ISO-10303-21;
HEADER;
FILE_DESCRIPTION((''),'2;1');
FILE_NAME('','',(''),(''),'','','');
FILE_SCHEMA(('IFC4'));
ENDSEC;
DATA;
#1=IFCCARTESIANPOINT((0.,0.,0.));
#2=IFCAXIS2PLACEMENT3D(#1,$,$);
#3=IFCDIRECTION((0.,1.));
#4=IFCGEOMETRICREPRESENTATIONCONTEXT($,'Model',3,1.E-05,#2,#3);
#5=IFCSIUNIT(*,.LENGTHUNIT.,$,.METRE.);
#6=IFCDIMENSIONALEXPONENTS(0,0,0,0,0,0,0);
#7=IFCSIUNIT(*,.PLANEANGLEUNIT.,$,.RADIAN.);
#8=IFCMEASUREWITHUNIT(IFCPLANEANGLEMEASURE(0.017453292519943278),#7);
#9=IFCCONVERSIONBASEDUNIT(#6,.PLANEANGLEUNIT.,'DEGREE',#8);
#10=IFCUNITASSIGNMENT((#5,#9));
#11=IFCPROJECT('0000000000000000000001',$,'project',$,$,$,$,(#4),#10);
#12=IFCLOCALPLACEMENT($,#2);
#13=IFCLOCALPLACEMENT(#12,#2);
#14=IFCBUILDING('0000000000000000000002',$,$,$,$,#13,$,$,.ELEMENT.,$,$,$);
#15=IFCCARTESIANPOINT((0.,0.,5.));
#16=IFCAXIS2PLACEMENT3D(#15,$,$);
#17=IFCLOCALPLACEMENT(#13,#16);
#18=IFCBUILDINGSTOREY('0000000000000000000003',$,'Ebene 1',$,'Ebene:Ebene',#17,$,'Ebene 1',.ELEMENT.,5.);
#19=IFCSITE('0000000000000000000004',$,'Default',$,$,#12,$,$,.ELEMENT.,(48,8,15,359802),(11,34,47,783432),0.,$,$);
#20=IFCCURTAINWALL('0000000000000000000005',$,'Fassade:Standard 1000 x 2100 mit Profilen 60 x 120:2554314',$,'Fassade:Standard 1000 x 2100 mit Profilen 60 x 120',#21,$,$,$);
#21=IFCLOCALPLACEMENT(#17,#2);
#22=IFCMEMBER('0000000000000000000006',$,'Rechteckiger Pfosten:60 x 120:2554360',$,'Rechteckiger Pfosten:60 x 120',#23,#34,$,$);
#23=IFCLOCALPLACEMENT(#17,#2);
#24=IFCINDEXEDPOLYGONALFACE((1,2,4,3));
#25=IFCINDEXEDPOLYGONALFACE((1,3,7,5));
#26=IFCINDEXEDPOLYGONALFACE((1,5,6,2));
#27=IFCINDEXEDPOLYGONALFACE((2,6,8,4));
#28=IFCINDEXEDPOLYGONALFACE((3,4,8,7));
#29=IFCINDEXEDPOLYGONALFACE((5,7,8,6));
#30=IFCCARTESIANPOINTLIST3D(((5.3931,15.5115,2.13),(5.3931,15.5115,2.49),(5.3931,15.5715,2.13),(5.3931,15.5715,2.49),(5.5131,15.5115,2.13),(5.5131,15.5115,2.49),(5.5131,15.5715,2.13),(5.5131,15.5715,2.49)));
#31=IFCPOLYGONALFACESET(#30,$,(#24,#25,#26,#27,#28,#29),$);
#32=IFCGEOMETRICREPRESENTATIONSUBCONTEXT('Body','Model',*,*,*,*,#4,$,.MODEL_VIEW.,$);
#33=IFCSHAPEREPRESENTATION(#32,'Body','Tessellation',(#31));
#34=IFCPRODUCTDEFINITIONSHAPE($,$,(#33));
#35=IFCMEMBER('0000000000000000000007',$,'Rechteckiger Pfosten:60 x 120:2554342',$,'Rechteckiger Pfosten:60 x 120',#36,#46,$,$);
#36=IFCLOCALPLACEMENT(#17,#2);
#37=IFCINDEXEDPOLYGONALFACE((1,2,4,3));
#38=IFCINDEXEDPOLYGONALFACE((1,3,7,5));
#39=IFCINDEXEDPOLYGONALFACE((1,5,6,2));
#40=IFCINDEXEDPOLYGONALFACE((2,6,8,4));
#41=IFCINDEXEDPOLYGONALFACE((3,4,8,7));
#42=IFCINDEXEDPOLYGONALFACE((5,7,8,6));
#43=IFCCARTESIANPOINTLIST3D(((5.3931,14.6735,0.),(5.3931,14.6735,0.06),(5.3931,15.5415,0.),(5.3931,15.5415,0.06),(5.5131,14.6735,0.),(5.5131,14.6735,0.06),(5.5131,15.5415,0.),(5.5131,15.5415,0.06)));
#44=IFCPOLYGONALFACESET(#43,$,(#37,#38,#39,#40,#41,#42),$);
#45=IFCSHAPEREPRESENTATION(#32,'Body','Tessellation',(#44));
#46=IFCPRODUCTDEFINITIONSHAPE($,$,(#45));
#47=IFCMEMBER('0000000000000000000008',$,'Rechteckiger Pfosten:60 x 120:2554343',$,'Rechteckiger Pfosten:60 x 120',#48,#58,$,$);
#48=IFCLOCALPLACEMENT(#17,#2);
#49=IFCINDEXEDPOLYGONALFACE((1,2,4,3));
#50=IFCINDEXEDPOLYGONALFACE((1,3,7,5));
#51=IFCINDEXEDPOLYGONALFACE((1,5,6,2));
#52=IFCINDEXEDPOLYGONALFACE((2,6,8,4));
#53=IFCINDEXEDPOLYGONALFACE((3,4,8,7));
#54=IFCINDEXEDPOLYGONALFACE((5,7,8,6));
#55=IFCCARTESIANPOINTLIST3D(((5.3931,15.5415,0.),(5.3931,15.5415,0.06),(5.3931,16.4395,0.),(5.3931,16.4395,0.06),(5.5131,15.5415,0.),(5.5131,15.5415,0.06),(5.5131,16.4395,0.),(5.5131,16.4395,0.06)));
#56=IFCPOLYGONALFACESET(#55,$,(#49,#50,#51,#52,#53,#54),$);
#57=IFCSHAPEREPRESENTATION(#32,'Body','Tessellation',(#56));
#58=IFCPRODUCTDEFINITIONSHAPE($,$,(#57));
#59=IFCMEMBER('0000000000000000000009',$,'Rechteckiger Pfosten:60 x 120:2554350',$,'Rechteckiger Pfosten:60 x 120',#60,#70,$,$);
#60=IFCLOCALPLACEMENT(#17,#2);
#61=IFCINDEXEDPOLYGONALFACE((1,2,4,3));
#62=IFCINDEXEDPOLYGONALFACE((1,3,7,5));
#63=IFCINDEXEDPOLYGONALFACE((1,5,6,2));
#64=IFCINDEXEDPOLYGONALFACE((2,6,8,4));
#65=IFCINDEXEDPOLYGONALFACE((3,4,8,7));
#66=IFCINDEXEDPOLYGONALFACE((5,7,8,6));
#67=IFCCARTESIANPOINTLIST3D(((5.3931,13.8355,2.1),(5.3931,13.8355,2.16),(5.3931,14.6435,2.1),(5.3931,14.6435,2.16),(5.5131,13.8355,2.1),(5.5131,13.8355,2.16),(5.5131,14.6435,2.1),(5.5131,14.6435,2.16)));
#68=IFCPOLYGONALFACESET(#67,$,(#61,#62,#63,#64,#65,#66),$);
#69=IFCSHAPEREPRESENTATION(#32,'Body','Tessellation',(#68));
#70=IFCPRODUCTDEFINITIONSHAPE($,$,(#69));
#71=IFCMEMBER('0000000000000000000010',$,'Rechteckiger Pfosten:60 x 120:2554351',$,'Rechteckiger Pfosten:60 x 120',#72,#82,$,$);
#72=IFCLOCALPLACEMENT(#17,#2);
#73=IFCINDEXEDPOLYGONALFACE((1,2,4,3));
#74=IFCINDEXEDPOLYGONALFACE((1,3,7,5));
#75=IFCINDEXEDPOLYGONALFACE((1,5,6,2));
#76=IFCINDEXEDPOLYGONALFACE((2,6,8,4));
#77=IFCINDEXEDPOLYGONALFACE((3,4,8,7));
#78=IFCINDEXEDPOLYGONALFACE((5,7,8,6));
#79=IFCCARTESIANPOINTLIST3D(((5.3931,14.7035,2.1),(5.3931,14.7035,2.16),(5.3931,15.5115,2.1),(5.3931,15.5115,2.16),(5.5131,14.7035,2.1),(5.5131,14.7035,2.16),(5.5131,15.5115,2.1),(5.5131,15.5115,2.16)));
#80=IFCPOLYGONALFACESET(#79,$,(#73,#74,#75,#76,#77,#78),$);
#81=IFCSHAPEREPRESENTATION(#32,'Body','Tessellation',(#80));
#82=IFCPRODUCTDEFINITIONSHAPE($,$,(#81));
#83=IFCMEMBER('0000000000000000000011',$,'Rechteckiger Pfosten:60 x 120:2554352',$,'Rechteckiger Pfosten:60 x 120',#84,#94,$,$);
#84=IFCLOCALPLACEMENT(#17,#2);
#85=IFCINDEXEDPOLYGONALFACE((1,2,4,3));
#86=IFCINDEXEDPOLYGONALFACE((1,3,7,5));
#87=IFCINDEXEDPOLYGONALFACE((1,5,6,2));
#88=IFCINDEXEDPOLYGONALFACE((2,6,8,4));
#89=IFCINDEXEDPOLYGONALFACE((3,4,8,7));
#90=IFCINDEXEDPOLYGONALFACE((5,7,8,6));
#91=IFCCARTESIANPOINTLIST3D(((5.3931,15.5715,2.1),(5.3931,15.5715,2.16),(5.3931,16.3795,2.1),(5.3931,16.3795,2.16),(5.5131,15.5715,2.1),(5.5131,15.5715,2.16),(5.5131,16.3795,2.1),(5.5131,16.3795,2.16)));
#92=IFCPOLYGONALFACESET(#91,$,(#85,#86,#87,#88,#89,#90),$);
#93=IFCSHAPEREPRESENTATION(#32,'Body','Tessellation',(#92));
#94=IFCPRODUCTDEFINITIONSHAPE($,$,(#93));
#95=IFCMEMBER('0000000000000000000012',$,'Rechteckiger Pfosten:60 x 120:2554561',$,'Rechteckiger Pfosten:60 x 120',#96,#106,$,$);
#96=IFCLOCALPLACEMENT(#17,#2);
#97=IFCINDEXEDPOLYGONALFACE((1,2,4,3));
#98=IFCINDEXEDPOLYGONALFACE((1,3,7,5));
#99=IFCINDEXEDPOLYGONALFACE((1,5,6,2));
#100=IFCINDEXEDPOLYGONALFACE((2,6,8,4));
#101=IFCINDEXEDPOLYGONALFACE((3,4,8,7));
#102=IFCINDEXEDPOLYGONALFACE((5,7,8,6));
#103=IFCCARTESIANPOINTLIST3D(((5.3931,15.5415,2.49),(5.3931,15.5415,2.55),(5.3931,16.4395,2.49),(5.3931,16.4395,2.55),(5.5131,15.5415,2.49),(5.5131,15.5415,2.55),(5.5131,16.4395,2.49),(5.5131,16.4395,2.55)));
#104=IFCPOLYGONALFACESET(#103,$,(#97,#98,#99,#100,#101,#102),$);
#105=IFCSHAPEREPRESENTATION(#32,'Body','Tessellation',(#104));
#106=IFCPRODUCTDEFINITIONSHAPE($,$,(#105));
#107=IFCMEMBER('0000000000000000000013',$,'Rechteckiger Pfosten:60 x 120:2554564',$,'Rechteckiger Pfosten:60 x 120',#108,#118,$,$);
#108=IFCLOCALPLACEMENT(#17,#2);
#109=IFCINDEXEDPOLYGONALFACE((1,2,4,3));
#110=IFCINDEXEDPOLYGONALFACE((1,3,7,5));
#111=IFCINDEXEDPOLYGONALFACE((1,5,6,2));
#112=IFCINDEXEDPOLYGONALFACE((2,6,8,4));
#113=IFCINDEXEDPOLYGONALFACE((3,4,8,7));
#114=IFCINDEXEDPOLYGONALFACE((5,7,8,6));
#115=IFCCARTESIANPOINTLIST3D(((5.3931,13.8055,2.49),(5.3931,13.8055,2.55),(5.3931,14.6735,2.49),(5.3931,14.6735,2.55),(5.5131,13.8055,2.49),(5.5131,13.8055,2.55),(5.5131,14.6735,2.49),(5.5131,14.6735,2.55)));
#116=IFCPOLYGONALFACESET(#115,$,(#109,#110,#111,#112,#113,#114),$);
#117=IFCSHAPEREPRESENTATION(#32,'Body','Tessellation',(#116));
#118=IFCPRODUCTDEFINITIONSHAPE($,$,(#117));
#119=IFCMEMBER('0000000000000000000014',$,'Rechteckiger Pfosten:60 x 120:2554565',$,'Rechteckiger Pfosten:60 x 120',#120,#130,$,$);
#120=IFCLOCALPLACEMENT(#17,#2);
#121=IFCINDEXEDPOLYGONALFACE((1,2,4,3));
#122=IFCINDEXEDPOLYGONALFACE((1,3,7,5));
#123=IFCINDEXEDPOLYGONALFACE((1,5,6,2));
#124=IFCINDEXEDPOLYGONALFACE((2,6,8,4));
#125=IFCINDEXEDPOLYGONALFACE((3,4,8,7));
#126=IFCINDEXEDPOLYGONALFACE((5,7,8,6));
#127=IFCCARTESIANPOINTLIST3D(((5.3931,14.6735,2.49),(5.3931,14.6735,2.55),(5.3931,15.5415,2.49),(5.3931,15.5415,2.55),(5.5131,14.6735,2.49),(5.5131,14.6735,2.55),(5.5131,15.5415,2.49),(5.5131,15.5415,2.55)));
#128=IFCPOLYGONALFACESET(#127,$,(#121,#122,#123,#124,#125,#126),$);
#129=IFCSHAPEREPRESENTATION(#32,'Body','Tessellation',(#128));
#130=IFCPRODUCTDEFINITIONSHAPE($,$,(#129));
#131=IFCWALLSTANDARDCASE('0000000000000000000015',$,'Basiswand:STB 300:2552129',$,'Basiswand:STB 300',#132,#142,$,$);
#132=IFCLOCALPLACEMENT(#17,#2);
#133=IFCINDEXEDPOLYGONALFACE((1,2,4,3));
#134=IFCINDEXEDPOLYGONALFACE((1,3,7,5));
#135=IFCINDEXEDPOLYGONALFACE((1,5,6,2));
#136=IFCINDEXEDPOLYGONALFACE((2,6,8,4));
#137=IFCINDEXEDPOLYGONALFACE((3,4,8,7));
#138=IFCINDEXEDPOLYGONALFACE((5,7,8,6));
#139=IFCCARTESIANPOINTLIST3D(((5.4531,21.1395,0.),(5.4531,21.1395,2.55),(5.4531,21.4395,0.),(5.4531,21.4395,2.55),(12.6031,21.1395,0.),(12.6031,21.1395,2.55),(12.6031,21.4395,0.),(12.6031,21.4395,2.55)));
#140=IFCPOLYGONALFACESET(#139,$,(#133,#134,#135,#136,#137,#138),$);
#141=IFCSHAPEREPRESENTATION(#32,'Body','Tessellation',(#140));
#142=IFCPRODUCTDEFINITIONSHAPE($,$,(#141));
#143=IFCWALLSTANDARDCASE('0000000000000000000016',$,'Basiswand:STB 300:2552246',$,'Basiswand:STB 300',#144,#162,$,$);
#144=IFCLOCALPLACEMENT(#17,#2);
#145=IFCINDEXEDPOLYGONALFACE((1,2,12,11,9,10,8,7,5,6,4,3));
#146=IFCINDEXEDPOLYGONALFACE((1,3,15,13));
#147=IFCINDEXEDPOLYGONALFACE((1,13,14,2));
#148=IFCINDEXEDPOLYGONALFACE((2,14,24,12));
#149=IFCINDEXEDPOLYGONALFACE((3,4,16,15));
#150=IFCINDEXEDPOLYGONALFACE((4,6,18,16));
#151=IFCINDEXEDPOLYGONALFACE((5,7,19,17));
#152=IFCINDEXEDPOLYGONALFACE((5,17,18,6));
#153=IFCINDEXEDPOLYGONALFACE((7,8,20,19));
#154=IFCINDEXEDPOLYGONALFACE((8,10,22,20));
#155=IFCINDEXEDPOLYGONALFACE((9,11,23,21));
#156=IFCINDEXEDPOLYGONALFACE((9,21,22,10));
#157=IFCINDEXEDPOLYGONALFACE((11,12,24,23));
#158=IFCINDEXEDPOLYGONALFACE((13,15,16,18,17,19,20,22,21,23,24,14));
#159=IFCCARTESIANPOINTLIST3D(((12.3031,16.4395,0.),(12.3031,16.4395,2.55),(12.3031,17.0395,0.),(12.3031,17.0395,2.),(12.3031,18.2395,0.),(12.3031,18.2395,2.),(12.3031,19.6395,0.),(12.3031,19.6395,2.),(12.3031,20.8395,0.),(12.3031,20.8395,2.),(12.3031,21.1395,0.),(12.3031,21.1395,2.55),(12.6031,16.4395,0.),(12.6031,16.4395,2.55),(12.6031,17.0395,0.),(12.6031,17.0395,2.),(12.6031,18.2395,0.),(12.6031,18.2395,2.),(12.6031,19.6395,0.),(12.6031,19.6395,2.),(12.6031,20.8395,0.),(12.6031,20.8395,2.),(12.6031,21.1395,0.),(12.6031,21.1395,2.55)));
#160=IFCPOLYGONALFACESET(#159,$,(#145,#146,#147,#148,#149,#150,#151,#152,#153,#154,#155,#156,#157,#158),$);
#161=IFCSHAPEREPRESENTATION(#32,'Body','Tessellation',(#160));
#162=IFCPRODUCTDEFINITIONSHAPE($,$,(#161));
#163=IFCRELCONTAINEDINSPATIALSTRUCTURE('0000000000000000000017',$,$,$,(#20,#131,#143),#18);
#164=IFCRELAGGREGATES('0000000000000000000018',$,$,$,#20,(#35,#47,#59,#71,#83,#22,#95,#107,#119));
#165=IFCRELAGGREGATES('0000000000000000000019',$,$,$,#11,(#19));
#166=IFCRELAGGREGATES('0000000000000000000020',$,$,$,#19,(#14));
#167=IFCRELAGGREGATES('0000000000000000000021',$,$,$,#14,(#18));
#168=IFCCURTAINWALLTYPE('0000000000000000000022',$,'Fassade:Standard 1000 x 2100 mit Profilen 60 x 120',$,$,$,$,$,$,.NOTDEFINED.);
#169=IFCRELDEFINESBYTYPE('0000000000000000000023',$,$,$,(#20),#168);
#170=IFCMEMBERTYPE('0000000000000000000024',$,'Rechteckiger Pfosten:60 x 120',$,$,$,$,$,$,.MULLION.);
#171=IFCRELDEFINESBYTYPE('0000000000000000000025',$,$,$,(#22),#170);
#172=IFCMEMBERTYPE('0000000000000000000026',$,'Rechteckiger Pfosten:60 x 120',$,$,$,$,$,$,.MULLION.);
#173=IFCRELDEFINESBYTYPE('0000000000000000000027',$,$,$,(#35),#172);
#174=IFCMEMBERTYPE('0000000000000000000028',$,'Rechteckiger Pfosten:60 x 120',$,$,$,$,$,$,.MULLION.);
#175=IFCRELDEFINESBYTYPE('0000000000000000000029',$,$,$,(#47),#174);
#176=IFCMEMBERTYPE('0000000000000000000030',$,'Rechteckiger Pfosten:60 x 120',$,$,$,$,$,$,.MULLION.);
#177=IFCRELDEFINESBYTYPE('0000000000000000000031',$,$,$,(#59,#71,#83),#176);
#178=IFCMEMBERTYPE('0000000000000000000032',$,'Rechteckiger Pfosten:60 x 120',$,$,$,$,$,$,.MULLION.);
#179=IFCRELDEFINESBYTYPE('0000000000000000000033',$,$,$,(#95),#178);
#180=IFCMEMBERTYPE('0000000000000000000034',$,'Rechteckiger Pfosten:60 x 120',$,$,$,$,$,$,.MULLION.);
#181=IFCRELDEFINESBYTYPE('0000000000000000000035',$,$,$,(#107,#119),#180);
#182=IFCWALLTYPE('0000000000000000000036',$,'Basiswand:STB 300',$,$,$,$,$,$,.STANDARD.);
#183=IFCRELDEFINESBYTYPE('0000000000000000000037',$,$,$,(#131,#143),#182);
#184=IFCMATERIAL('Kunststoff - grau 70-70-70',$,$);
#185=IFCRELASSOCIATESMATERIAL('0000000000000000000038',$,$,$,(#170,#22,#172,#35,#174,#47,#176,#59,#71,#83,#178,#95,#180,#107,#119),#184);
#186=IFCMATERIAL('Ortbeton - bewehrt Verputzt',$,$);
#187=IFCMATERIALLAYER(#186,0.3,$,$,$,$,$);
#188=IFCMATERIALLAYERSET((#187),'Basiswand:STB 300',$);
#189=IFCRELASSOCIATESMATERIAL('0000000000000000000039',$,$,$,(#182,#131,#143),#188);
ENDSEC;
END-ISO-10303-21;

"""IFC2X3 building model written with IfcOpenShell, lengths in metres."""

from ifc_helpers import new_model, entity, si_unit, converted_unit, direction, frame, frame_2d, origin, origin_2d_with_axis, place, context, subcontext, project, spatial, polyline, rectangle, extrude, clip, bounded_halfspace, source, transform, mapped, material, layer, layer_set, layer_usage, type_object, type_shapes, element, aggregate, save


model = new_model("IFC2X3")

# Units and contexts
model_context = context("Model", 3, precision=1e-05, world=origin(), true_north=direction((0.0, 1.0)))
body_context = subcontext(model_context, "Body", "Model", "MODEL_VIEW")
ifc_project = project(units=[si_unit("LENGTHUNIT", "METRE"), converted_unit("PLANEANGLEUNIT", "DEGREE", entity("IfcPlaneAngleMeasure", 0.017453292519943278), si_unit("PLANEANGLEUNIT", "RADIAN"), dimensions=[0, 0, 0, 0, 0, 0, 0])], contexts=[model_context])

# Site, building, storey
site_placement = place(None, origin())
site = spatial("IfcSite", under=ifc_project, at=site_placement, Name="Default", CompositionType="ELEMENT", RefLatitude=(48, 8, 15, 359802), RefLongitude=(11, 34, 47, 783432), RefElevation=0.0)
building_placement = place(site_placement, origin())
building = spatial("IfcBuilding", under=site, at=building_placement, CompositionType="ELEMENT")
storey_placement = place(building_placement, frame((0.0, 0.0, 5.0)))
storey = spatial("IfcBuildingStorey", under=building, at=storey_placement, Name="Ebene 1", ObjectType="Ebene:Ebene", LongName="Ebene 1", CompositionType="ELEMENT", Elevation=5.0)

# Shared definitions
ifc_material_1 = material(Name="Ortbeton - bewehrt Verputzt")

# Curtain wall
curtain_wall_type = type_object("IfcCurtainWallType", Name="Fassade:Standard 1000 x 2100 mit Profilen 60 x 120", PredefinedType="NOTDEFINED")
ifc_material_2 = material(Name="Kunststoff - grau 70-70-70")
curtain_wall_1_placement = place(storey_placement, frame((0.0, 0.0, -5.0)))
curtain_wall_1 = element("IfcCurtainWall", 1, at=curtain_wall_1_placement, inside=storey, type_object=curtain_wall_type, Name="Fassade:Standard 1000 x 2100 mit Profilen 60 x 120:2554314", ObjectType="Fassade:Standard 1000 x 2100 mit Profilen 60 x 120")

# Members
member_type_1 = type_object("IfcMemberType", Name="Rechteckiger Pfosten:60 x 120", PredefinedType="MULLION", material=ifc_material_2)
shared_shape_1 = source(origin(), body_context, "Body", "SweptSolid", [
    extrude(rectangle(XDim=0.06, YDim=0.12, at=frame_2d((0.0, 0.0), x_axis=(1.0, 0.0))), frame((0.0, 0.0, -0.36), z_axis=(0.0, 0.0, 1.0), x_axis=(-1.0, 0.0, 0.0)), (0.0, 0.0, 1.0), 0.36),
])
type_shapes(member_type_1, [shared_shape_1])
member_1_placement = place(curtain_wall_1_placement, frame((5.4531, 15.5415, 7.13), z_axis=(0.0, 0.0, -1.0), x_axis=(0.0, 1.0, 0.0)))
member_1 = element("IfcMember", 2, at=member_1_placement, type_object=member_type_1, material=ifc_material_2, Name="Rechteckiger Pfosten:60 x 120:2554360", ObjectType="Rechteckiger Pfosten:60 x 120", context=body_context, shape_type="MappedRepresentation", body=[
    mapped(shared_shape_1, transform((0.0, 0.0, 0.0), scale=1.0)),
])
member_type_2 = type_object("IfcMemberType", Name="Rechteckiger Pfosten:60 x 120", PredefinedType="MULLION", material=ifc_material_2)
shared_shape_2 = source(origin(), body_context, "Body", "SweptSolid", [
    extrude(rectangle(XDim=0.06, YDim=0.12, at=origin_2d_with_axis()), frame((-0.03, 0.0, -0.868), z_axis=(0.0, 0.0, 1.0), x_axis=(-1.0, 0.0, 0.0)), (0.0, 0.0, 1.0), 0.868),
])
type_shapes(member_type_2, [shared_shape_2])
member_2_placement = place(curtain_wall_1_placement, frame((5.4531, 14.6735, 5.0), z_axis=(0.0, -1.0, 0.0), x_axis=(0.0, 0.0, -1.0)))
member_2 = element("IfcMember", 3, at=member_2_placement, type_object=member_type_2, material=ifc_material_2, Name="Rechteckiger Pfosten:60 x 120:2554342", ObjectType="Rechteckiger Pfosten:60 x 120", context=body_context, shape_type="MappedRepresentation", body=[
    mapped(shared_shape_2, transform((0.0, 0.0, 0.0), scale=1.0)),
])
member_type_3 = type_object("IfcMemberType", Name="Rechteckiger Pfosten:60 x 120", PredefinedType="MULLION", material=ifc_material_2)
shared_shape_3 = source(origin(), body_context, "Body", "SweptSolid", [
    extrude(rectangle(XDim=0.06, YDim=0.12, at=origin_2d_with_axis()), frame((-0.03, 0.0, -0.898), z_axis=(0.0, 0.0, 1.0), x_axis=(-1.0, 0.0, 0.0)), (0.0, 0.0, 1.0), 0.898),
])
type_shapes(member_type_3, [shared_shape_3])
member_3_placement = place(curtain_wall_1_placement, frame((5.4531, 15.5415, 5.0), z_axis=(0.0, -1.0, 0.0), x_axis=(0.0, 0.0, -1.0)))
member_3 = element("IfcMember", 4, at=member_3_placement, type_object=member_type_3, material=ifc_material_2, Name="Rechteckiger Pfosten:60 x 120:2554343", ObjectType="Rechteckiger Pfosten:60 x 120", context=body_context, shape_type="MappedRepresentation", body=[
    mapped(shared_shape_3, transform((0.0, 0.0, 0.0), scale=1.0)),
])
member_type_4 = type_object("IfcMemberType", Name="Rechteckiger Pfosten:60 x 120", PredefinedType="MULLION", material=ifc_material_2)
shared_shape_4 = source(origin(), body_context, "Body", "SweptSolid", [
    extrude(rectangle(XDim=0.06, YDim=0.12, at=origin_2d_with_axis()), frame((0.0, 0.0, -0.808), z_axis=(0.0, 0.0, 1.0), x_axis=(-1.0, 0.0, 0.0)), (0.0, 0.0, 1.0), 0.808),
])
type_shapes(member_type_4, [shared_shape_4])
member_4_placement = place(curtain_wall_1_placement, frame((5.4531, 14.6435, 7.13), z_axis=(0.0, 1.0, 0.0), x_axis=(0.0, 0.0, 1.0)))
member_4 = element("IfcMember", 5, at=member_4_placement, type_object=member_type_4, material=ifc_material_2, Name="Rechteckiger Pfosten:60 x 120:2554350", ObjectType="Rechteckiger Pfosten:60 x 120", context=body_context, shape_type="MappedRepresentation", body=[
    mapped(shared_shape_4, transform((0.0, 0.0, 0.0), scale=1.0)),
])
member_5_placement = place(curtain_wall_1_placement, frame((5.4531, 15.5115, 7.13), z_axis=(0.0, 1.0, 0.0), x_axis=(0.0, 0.0, 1.0)))
member_5 = element("IfcMember", 6, at=member_5_placement, type_object=member_type_4, material=ifc_material_2, Name="Rechteckiger Pfosten:60 x 120:2554351", ObjectType="Rechteckiger Pfosten:60 x 120", context=body_context, shape_type="MappedRepresentation", body=[
    mapped(shared_shape_4, transform((0.0, 0.0, 0.0), scale=1.0)),
])
member_6_placement = place(curtain_wall_1_placement, frame((5.4531, 16.3795, 7.13), z_axis=(0.0, 1.0, 0.0), x_axis=(0.0, 0.0, 1.0)))
member_6 = element("IfcMember", 7, at=member_6_placement, type_object=member_type_4, material=ifc_material_2, Name="Rechteckiger Pfosten:60 x 120:2554352", ObjectType="Rechteckiger Pfosten:60 x 120", context=body_context, shape_type="MappedRepresentation", body=[
    mapped(shared_shape_4, transform((0.0, 0.0, 0.0), scale=1.0)),
])
member_type_5 = type_object("IfcMemberType", Name="Rechteckiger Pfosten:60 x 120", PredefinedType="MULLION", material=ifc_material_2)
shared_shape_5 = source(origin(), body_context, "Body", "SweptSolid", [
    extrude(rectangle(XDim=0.06, YDim=0.12, at=origin_2d_with_axis()), frame((-0.03, 0.0, -0.898), z_axis=(0.0, 0.0, 1.0), x_axis=(-1.0, 0.0, 0.0)), (0.0, 0.0, 1.0), 0.898),
])
type_shapes(member_type_5, [shared_shape_5])
member_7_placement = place(curtain_wall_1_placement, frame((5.4531, 16.4395, 7.55), z_axis=(0.0, 1.0, 0.0), x_axis=(0.0, 0.0, 1.0)))
member_7 = element("IfcMember", 8, at=member_7_placement, type_object=member_type_5, material=ifc_material_2, Name="Rechteckiger Pfosten:60 x 120:2554561", ObjectType="Rechteckiger Pfosten:60 x 120", context=body_context, shape_type="MappedRepresentation", body=[
    mapped(shared_shape_5, transform((0.0, 0.0, 0.0), scale=1.0)),
])
member_type_6 = type_object("IfcMemberType", Name="Rechteckiger Pfosten:60 x 120", PredefinedType="MULLION", material=ifc_material_2)
shared_shape_6 = source(origin(), body_context, "Body", "SweptSolid", [
    extrude(rectangle(XDim=0.06, YDim=0.12, at=origin_2d_with_axis()), frame((-0.03, 0.0, -0.868), z_axis=(0.0, 0.0, 1.0), x_axis=(-1.0, 0.0, 0.0)), (0.0, 0.0, 1.0), 0.868),
])
type_shapes(member_type_6, [shared_shape_6])
member_8_placement = place(curtain_wall_1_placement, frame((5.4531, 14.6735, 7.55), z_axis=(0.0, 1.0, 0.0), x_axis=(0.0, 0.0, 1.0)))
member_8 = element("IfcMember", 9, at=member_8_placement, type_object=member_type_6, material=ifc_material_2, Name="Rechteckiger Pfosten:60 x 120:2554564", ObjectType="Rechteckiger Pfosten:60 x 120", context=body_context, shape_type="MappedRepresentation", body=[
    mapped(shared_shape_6, transform((0.0, 0.0, 0.0), scale=1.0)),
])
member_9_placement = place(curtain_wall_1_placement, frame((5.4531, 15.5415, 7.55), z_axis=(0.0, 1.0, 0.0), x_axis=(0.0, 0.0, 1.0)))
member_9 = element("IfcMember", 10, at=member_9_placement, type_object=member_type_6, material=ifc_material_2, Name="Rechteckiger Pfosten:60 x 120:2554565", ObjectType="Rechteckiger Pfosten:60 x 120", context=body_context, shape_type="MappedRepresentation", body=[
    mapped(shared_shape_6, transform((0.0, 0.0, 0.0), scale=1.0)),
])

aggregate(curtain_wall_1, [member_2, member_3, member_4, member_5, member_6, member_1, member_7, member_8, member_9])

# Wall
ifc_layer = layer(ifc_material_1, 0.3)
ifc_layer_set = layer_set([ifc_layer], Name="Basiswand:STB 300")
ifc_layer_usage_1 = layer_usage(ifc_layer_set, "AXIS2", "NEGATIVE", 0.15)
wall_type = type_object("IfcWallType", Name="Basiswand:STB 300", PredefinedType="STANDARD", material=ifc_layer_set)
wall_1_placement = place(storey_placement, frame((5.4531, 21.2895, 0.0)))
element("IfcWallStandardCase", 11, at=wall_1_placement, inside=storey, type_object=wall_type, material=ifc_layer_usage_1, Name="Basiswand:STB 300:2552129", ObjectType="Basiswand:STB 300", context=body_context, shape_type="Clipping", body=[
    clip(extrude(rectangle(XDim=7.15, YDim=0.3, at=frame_2d((3.575, 0.0), x_axis=(-1.0, 0.0))), origin(), (0.0, 0.0, 1.0), 2.55), bounded_halfspace(frame((0.0, -0.15, 2.55), z_axis=(0.0, 0.0, -1.0), x_axis=(0.0, -1.0, 0.0)), True, frame((0.0, -0.15, 2.55)), polyline([(0.0, 0.0), (0.3, 0.0), (6.85, 0.0), (7.15, 0.0), (7.15, 0.3), (0.0, 0.3), (0.0, 0.0)]))),
])

# Wall, openings
ifc_layer_usage_2 = layer_usage(ifc_layer_set, "AXIS2", "NEGATIVE", 0.15)
wall_2_placement = place(storey_placement, frame((12.4531, 21.1395, 0.0), z_axis=(0.0, 0.0, 1.0), x_axis=(0.0, -1.0, 0.0)))
wall_2 = element("IfcWallStandardCase", 12, at=wall_2_placement, inside=storey, type_object=wall_type, material=ifc_layer_usage_2, Name="Basiswand:STB 300:2552246", ObjectType="Basiswand:STB 300", context=body_context, shape_type="Clipping", body=[
    clip(extrude(rectangle(XDim=4.7, YDim=0.3, at=frame_2d((2.35, 0.0), x_axis=(-1.0, 0.0))), origin(), (0.0, 0.0, 1.0), 2.55), bounded_halfspace(frame((0.0, -0.15, 2.55), z_axis=(0.0, 0.0, -1.0), x_axis=(1.0, 0.0, 0.0)), True, frame((0.0, -0.15, 2.55)), polyline([(0.0, 0.0), (4.4, 0.0), (4.7, 0.0), (4.7, 0.3), (0.0, 0.3), (0.0, 0.0)]))),
])
opening_1_placement = place(wall_2_placement, frame((21.1395, -12.4531, 0.0), z_axis=(0.0, 0.0, 1.0), x_axis=(0.0, 1.0, 0.0)))
element("IfcOpeningElement", 13, at=opening_1_placement, cuts=wall_2, ObjectType="Opening", context=body_context, shape_type="SweptSolid", body=[
    extrude(rectangle(XDim=2.18, YDim=1.2, at=frame_2d((0.0, 0.0), x_axis=(0.0, 1.0))), frame((10.7791, 20.2395, 0.91), z_axis=(1.0, 0.0, 0.0), x_axis=(0.0, 1.0, 0.0)), (0.0, 0.0, 1.0), 3.048),
])
opening_2_placement = place(wall_2_placement, frame((21.1395, -12.4531, 0.0), z_axis=(0.0, 0.0, 1.0), x_axis=(0.0, 1.0, 0.0)))
element("IfcOpeningElement", 14, at=opening_2_placement, cuts=wall_2, ObjectType="Opening", context=body_context, shape_type="SweptSolid", body=[
    extrude(rectangle(XDim=2.18, YDim=1.2, at=frame_2d((0.0, 0.0), x_axis=(0.0, 1.0))), frame((10.7791, 17.6395, 0.91), z_axis=(1.0, 0.0, 0.0), x_axis=(0.0, 1.0, 0.0)), (0.0, 0.0, 1.0), 3.048),
])

save(model, "model.ifc")
